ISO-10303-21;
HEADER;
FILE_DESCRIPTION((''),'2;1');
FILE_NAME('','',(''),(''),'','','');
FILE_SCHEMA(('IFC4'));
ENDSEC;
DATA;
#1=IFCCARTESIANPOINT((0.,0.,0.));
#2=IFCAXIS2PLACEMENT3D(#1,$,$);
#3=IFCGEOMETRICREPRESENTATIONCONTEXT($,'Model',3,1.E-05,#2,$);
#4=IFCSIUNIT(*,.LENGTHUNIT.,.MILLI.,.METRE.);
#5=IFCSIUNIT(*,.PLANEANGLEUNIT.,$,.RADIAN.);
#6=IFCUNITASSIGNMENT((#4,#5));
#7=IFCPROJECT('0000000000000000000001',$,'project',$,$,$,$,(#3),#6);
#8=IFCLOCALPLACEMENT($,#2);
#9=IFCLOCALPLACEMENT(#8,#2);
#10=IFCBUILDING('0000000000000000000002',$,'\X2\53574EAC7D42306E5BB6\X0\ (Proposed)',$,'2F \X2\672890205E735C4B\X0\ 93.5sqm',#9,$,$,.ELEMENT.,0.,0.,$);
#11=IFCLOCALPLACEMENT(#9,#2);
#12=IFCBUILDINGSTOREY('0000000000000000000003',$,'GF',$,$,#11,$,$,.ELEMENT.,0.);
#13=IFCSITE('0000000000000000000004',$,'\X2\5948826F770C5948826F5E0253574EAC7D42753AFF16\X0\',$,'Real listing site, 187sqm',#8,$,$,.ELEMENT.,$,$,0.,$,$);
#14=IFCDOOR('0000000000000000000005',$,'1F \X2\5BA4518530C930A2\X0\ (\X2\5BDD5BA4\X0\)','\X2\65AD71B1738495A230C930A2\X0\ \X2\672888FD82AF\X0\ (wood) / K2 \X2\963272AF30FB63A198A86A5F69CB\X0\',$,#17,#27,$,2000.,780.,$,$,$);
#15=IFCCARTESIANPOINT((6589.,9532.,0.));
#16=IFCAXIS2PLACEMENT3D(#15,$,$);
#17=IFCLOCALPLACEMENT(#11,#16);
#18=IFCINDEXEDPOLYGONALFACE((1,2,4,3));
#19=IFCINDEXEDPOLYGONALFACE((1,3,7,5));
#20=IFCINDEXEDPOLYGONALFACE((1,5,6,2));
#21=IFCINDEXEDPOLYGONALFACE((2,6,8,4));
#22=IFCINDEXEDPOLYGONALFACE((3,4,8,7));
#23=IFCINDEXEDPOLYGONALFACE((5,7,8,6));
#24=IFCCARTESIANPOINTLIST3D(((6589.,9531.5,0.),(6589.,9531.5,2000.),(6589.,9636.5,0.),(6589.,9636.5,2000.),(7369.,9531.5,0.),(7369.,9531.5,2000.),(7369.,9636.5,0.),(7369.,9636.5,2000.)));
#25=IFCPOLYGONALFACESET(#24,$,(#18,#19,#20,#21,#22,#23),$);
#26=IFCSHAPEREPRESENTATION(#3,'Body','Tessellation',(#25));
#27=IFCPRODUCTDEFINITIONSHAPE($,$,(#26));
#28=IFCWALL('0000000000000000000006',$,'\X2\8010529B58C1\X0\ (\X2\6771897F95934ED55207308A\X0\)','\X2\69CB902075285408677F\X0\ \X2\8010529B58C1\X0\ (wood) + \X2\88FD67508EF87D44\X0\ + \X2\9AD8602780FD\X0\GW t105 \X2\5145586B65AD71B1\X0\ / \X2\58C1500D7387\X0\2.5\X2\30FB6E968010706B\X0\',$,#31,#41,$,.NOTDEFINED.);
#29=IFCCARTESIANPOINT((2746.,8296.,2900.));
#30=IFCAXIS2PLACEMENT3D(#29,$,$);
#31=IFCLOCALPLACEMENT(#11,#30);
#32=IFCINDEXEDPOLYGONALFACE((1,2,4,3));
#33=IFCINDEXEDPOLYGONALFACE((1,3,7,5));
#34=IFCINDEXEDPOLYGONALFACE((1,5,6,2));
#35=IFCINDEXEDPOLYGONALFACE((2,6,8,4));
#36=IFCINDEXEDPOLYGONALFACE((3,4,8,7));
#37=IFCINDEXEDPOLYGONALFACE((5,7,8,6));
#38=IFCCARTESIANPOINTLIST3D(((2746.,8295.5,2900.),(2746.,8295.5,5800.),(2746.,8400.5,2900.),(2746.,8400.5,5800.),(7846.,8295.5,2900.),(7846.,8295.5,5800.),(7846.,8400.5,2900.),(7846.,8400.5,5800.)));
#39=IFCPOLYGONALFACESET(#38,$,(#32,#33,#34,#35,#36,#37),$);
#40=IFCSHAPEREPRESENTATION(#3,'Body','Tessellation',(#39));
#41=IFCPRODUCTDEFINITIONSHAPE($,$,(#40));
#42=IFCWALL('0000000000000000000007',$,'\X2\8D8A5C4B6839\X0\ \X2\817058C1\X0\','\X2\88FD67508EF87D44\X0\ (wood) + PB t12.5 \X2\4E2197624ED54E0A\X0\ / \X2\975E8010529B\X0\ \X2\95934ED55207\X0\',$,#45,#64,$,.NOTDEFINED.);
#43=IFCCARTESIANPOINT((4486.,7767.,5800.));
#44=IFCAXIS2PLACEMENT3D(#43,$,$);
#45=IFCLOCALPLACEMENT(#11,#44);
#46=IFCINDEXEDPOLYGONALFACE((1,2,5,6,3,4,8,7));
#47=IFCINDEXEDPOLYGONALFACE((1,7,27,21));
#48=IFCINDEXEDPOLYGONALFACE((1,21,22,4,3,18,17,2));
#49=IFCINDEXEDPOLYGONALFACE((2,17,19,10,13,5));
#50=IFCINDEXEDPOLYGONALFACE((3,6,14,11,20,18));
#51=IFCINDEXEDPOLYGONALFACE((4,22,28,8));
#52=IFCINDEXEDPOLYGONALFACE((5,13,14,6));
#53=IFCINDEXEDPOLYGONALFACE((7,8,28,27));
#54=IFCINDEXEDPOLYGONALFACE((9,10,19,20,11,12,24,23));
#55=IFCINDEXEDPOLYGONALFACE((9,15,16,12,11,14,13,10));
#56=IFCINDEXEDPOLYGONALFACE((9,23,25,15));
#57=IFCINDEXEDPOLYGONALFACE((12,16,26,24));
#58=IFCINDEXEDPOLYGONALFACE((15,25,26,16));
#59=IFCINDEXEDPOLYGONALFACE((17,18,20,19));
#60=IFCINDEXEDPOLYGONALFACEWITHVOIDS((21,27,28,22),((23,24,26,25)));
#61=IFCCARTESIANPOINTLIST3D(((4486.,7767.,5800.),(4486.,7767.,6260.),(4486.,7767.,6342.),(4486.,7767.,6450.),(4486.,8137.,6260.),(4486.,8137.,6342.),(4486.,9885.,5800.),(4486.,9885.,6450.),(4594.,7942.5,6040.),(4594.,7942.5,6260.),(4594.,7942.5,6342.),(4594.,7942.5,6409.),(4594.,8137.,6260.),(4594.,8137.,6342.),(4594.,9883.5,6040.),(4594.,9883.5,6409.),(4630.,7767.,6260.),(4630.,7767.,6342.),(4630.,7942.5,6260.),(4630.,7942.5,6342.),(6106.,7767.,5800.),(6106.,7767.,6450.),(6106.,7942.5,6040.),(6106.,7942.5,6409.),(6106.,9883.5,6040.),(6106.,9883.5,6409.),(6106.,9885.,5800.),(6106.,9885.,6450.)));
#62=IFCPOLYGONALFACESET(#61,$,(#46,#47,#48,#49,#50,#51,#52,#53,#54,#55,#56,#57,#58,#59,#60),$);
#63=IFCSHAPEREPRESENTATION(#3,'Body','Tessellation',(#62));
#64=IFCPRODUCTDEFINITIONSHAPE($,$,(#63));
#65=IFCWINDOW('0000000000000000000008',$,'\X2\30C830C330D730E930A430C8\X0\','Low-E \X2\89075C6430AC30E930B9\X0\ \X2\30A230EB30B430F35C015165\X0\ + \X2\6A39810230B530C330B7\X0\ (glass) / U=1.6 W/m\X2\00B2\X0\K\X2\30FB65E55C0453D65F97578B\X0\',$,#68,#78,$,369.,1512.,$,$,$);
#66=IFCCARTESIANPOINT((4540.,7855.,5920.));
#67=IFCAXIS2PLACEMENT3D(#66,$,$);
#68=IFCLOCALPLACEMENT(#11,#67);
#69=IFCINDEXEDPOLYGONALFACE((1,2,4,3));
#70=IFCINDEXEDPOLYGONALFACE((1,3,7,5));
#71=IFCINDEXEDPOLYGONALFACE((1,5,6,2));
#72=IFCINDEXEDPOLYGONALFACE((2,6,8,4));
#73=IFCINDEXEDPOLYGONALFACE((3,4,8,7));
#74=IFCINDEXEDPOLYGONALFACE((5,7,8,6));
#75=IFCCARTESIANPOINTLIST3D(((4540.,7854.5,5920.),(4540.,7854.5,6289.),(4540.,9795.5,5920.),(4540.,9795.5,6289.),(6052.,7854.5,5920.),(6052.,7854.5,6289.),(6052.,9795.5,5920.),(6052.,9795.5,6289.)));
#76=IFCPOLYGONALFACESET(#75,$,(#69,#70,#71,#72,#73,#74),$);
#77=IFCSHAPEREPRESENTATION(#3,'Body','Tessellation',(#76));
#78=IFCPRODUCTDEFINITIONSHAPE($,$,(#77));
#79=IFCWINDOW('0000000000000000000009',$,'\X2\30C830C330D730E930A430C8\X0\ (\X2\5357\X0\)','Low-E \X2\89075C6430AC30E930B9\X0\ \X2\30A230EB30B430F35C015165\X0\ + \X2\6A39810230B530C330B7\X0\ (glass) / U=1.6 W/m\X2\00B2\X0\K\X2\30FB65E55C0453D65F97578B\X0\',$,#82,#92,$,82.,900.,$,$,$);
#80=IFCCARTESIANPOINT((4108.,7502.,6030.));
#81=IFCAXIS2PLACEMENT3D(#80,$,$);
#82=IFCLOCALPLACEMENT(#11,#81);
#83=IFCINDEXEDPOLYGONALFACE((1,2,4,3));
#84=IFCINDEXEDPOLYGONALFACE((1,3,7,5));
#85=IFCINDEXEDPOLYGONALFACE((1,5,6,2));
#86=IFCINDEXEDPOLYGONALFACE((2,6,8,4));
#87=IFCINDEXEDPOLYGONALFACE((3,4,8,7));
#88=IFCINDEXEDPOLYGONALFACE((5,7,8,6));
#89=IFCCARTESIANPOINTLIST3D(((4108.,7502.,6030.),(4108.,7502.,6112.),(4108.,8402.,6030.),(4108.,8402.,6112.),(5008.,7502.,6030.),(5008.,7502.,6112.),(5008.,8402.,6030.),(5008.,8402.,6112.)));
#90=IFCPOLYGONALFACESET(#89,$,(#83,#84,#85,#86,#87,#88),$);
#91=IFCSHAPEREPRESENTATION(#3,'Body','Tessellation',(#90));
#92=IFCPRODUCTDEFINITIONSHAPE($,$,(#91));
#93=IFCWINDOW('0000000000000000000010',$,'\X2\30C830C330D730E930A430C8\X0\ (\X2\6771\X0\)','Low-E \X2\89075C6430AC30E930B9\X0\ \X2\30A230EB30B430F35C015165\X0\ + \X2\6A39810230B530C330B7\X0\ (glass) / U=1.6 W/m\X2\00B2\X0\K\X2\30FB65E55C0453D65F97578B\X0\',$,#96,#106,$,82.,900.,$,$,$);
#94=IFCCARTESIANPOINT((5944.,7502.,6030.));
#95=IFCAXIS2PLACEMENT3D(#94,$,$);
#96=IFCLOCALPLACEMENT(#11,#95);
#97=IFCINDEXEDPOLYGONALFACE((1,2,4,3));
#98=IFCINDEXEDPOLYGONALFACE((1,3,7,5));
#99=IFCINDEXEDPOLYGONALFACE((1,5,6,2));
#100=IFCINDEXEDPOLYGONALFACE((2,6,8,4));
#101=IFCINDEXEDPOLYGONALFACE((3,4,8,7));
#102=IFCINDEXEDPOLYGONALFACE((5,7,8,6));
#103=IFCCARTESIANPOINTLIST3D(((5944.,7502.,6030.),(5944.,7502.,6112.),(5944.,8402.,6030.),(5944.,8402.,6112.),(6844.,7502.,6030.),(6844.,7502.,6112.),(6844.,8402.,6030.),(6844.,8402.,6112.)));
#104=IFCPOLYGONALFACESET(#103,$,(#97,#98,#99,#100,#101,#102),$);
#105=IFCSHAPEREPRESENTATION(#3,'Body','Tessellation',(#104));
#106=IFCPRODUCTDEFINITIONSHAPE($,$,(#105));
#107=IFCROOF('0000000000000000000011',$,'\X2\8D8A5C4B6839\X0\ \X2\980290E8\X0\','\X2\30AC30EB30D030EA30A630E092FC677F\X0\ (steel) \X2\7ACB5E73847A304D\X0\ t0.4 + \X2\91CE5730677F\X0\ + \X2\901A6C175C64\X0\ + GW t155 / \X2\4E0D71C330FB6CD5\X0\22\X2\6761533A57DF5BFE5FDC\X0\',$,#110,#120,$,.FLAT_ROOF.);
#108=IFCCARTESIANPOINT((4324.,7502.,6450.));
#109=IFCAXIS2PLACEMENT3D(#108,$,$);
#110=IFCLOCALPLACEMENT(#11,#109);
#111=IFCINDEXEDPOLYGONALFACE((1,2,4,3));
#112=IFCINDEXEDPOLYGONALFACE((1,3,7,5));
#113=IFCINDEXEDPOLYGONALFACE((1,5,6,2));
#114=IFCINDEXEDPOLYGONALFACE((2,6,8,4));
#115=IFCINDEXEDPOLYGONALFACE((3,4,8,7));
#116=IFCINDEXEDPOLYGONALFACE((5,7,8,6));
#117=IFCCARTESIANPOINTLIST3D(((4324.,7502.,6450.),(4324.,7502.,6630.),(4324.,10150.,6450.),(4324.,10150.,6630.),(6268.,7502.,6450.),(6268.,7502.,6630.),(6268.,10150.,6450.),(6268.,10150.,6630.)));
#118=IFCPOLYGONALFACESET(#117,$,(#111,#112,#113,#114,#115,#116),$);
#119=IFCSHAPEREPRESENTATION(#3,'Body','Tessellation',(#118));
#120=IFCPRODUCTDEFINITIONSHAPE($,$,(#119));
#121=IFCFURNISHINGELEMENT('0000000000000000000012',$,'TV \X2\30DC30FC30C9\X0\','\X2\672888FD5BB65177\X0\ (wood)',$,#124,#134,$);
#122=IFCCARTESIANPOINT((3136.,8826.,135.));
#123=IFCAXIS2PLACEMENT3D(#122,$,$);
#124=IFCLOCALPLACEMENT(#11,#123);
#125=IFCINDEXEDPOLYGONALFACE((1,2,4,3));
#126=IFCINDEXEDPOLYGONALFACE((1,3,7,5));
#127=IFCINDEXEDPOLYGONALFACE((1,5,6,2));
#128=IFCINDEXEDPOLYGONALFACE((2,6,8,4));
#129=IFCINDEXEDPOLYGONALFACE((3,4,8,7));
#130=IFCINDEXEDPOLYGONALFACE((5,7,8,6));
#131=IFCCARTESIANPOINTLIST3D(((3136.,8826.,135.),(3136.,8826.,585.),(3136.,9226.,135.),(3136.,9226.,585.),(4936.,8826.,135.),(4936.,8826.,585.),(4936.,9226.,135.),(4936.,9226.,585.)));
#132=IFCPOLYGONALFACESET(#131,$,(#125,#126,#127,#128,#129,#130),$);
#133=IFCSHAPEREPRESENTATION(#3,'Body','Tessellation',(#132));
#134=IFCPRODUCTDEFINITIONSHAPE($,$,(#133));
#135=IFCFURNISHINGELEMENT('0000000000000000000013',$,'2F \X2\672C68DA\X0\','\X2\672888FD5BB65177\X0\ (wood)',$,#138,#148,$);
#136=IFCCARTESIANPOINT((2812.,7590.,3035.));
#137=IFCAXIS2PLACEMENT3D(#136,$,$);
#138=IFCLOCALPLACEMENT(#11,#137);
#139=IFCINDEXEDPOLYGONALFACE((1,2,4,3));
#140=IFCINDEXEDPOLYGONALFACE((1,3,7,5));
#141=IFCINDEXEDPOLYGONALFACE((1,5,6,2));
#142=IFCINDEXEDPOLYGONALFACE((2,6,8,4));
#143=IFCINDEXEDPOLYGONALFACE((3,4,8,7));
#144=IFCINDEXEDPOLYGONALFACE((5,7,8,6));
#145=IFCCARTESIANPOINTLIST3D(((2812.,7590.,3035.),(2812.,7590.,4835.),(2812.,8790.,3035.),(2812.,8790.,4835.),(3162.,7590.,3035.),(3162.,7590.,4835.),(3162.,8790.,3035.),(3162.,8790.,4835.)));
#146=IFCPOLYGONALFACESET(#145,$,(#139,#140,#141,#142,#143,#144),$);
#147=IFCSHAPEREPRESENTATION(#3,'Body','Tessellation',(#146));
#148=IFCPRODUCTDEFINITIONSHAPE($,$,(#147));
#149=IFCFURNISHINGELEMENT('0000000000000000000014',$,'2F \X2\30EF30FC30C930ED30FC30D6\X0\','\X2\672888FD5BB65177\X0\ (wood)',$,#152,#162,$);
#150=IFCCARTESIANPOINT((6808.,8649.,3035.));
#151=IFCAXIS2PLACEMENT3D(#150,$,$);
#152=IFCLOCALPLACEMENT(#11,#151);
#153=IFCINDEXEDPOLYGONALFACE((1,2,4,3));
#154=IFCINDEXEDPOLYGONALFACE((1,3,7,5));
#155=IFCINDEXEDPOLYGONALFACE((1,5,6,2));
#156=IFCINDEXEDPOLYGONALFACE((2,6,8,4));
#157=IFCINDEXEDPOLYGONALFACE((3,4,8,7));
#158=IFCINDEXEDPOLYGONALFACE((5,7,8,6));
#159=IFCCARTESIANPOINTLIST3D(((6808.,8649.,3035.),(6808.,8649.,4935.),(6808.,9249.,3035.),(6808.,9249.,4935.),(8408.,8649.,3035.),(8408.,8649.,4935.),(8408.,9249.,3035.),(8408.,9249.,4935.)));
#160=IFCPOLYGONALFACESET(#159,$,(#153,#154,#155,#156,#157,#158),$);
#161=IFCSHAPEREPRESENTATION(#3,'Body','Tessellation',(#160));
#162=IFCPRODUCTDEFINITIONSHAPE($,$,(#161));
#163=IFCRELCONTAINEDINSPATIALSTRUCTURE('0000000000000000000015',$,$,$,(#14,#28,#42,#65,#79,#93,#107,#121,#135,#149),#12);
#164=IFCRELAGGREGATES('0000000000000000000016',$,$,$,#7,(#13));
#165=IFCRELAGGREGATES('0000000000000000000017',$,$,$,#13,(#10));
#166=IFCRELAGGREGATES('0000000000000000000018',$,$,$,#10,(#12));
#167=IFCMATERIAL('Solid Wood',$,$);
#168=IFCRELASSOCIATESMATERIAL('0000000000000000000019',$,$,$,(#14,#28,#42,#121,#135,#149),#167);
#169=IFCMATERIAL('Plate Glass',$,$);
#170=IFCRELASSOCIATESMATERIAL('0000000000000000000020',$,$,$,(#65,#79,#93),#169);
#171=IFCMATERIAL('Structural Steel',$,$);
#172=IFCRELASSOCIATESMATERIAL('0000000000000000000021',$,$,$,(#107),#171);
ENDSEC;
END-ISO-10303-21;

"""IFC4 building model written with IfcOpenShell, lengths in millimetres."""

from ifc_helpers import new_model, si_unit, frame, frame_2d, origin, place, context, project, spatial, rectangle, extrude, material, element, fill, save


model = new_model("IFC4")

# Units and contexts
model_context = context("Model", 3, precision=1e-05, world=origin())
ifc_project = project(units=[si_unit("LENGTHUNIT", "METRE", prefix="MILLI"), si_unit("PLANEANGLEUNIT", "RADIAN")], contexts=[model_context])

# Site, building, storey
site_placement = place(None, origin())
site = spatial("IfcSite", under=ifc_project, at=site_placement, Name="奈良県奈良市南京終町６", ObjectType="Real listing site, 187sqm", CompositionType="ELEMENT", RefElevation=0.0)
building_placement = place(site_placement, origin())
building = spatial("IfcBuilding", under=site, at=building_placement, Name="南京終の家 (Proposed)", ObjectType="2F 木造平屋 93.5sqm", CompositionType="ELEMENT", ElevationOfRefHeight=0.0, ElevationOfTerrain=0.0)
storey_placement = place(building_placement, origin())
storey = spatial("IfcBuildingStorey", under=building, at=storey_placement, Name="GF", CompositionType="ELEMENT", Elevation=0.0)

# Shared definitions
ifc_material_1 = material(Name="Solid Wood")

# Door
door_placement = place(storey_placement, frame((6589.0, 9532.0, 0.0)))
element("IfcDoor", 1, at=door_placement, inside=storey, material=ifc_material_1, Name="1F 室内ドア (寝室)", Description="断熱玄関ドア 木製芯 (wood) / K2 防犯・採風機構", OverallHeight=2000.0, OverallWidth=780.0, context=model_context, shape_type="SweptSolid", body=[
    extrude(rectangle(XDim=780.0, YDim=105.0, at=frame_2d((390.0, 52.0))), frame((6589.0, 9532.0, 0.0)), (0.0, 0.0, 1.0), 2000.0),
])

# Wall
wall_1_placement = place(storey_placement, frame((2746.0, 8296.0, 2900.0)))
element("IfcWall", 2, at=wall_1_placement, inside=storey, material=ifc_material_1, Name="耐力壁 (東西間仕切り)", Description="構造用合板 耐力壁 (wood) + 製材軸組 + 高性能GW t105 充填断熱 / 壁倍率2.5・準耐火", PredefinedType="NOTDEFINED", context=model_context, shape_type="SweptSolid", body=[
    extrude(rectangle(XDim=5100.0, YDim=105.0, at=frame_2d((2550.0, 52.0))), frame((2746.0, 8296.0, 2900.0)), (0.0, 0.0, 1.0), 2900.0),
])

# Wall, openings, windows
wall_2_placement = place(storey_placement, frame((4486.0, 7767.0, 5800.0)))
wall_2 = element("IfcWall", 3, at=wall_2_placement, inside=storey, material=ifc_material_1, Name="越屋根 腰壁", Description="製材軸組 (wood) + PB t12.5 両面仕上 / 非耐力 間仕切", PredefinedType="NOTDEFINED", context=model_context, shape_type="SweptSolid", body=[
    extrude(rectangle(XDim=1620.0, YDim=2118.0, at=frame_2d((810.0, 1059.0))), frame((4486.0, 7767.0, 5800.0)), (0.0, 0.0, 1.0), 650.0),
])
opening_1_placement = place(storey_placement, frame((4540.0, 7855.0, 5920.0)))
opening_1 = element("IfcOpeningElement", 4, at=opening_1_placement, cuts=wall_2, PredefinedType="NOTDEFINED", context=model_context, shape_type="SweptSolid", body=[
    extrude(rectangle(XDim=1512.0, YDim=1941.0, at=frame_2d((756.0, 970.0))), frame((4540.0, 7855.0, 5920.0)), (0.0, 0.0, 1.0), 369.0),
])
opening_2_placement = place(storey_placement, frame((4108.0, 7502.0, 6030.0)))
opening_2 = element("IfcOpeningElement", 5, at=opening_2_placement, cuts=wall_2, PredefinedType="NOTDEFINED", context=model_context, shape_type="SweptSolid", body=[
    extrude(rectangle(XDim=900.0, YDim=900.0, at=frame_2d((450.0, 450.0))), frame((4108.0, 7502.0, 6030.0)), (0.0, 0.0, 1.0), 82.0),
])
opening_3_placement = place(storey_placement, frame((5944.0, 7502.0, 6030.0)))
opening_3 = element("IfcOpeningElement", 6, at=opening_3_placement, cuts=wall_2, PredefinedType="NOTDEFINED", context=model_context, shape_type="SweptSolid", body=[
    extrude(rectangle(XDim=900.0, YDim=900.0, at=frame_2d((450.0, 450.0))), frame((5944.0, 7502.0, 6030.0)), (0.0, 0.0, 1.0), 82.0),
])
ifc_material_2 = material(Name="Plate Glass")
window_1_placement = place(storey_placement, frame((4540.0, 7855.0, 5920.0)))
window_1 = element("IfcWindow", 7, at=window_1_placement, inside=storey, material=ifc_material_2, Name="トップライト", Description="Low-E 複層ガラス アルゴン封入 + 樹脂サッシ (glass) / U=1.6 W/m²K・日射取得型", OverallHeight=369.0, OverallWidth=1512.0, context=model_context, shape_type="SweptSolid", body=[
    extrude(rectangle(XDim=1512.0, YDim=1941.0, at=frame_2d((756.0, 970.0))), frame((4540.0, 7855.0, 5920.0)), (0.0, 0.0, 1.0), 369.0),
])
fill(opening_1, window_1)
window_2_placement = place(storey_placement, frame((4108.0, 7502.0, 6030.0)))
window_2 = element("IfcWindow", 8, at=window_2_placement, inside=storey, material=ifc_material_2, Name="トップライト (南)", Description="Low-E 複層ガラス アルゴン封入 + 樹脂サッシ (glass) / U=1.6 W/m²K・日射取得型", OverallHeight=82.0, OverallWidth=900.0, context=model_context, shape_type="SweptSolid", body=[
    extrude(rectangle(XDim=900.0, YDim=900.0, at=frame_2d((450.0, 450.0))), frame((4108.0, 7502.0, 6030.0)), (0.0, 0.0, 1.0), 82.0),
])
fill(opening_2, window_2)
window_3_placement = place(storey_placement, frame((5944.0, 7502.0, 6030.0)))
window_3 = element("IfcWindow", 9, at=window_3_placement, inside=storey, material=ifc_material_2, Name="トップライト (東)", Description="Low-E 複層ガラス アルゴン封入 + 樹脂サッシ (glass) / U=1.6 W/m²K・日射取得型", OverallHeight=82.0, OverallWidth=900.0, context=model_context, shape_type="SweptSolid", body=[
    extrude(rectangle(XDim=900.0, YDim=900.0, at=frame_2d((450.0, 450.0))), frame((5944.0, 7502.0, 6030.0)), (0.0, 0.0, 1.0), 82.0),
])
fill(opening_3, window_3)

# Roof
ifc_material_3 = material(Name="Structural Steel")
roof_placement = place(storey_placement, frame((4324.0, 7502.0, 6450.0)))
element("IfcRoof", 10, at=roof_placement, inside=storey, material=ifc_material_3, Name="越屋根 頂部", Description="ガルバリウム鋼板 (steel) 立平葺き t0.4 + 野地板 + 通気層 + GW t155 / 不燃・法22条区域対応", PredefinedType="FLAT_ROOF", context=model_context, shape_type="SweptSolid", body=[
    extrude(rectangle(XDim=1944.0, YDim=2648.0, at=frame_2d((972.0, 1324.0))), frame((4324.0, 7502.0, 6450.0)), (0.0, 0.0, 1.0), 180.0),
])

# Furnishing elements
furnishing_1_placement = place(storey_placement, frame((3136.0, 8826.0, 135.0)))
element("IfcFurnishingElement", 11, at=furnishing_1_placement, inside=storey, material=ifc_material_1, Name="TV ボード", Description="木製家具 (wood)", context=model_context, shape_type="SweptSolid", body=[
    extrude(rectangle(XDim=1800.0, YDim=400.0, at=frame_2d((900.0, 200.0))), frame((3136.0, 8826.0, 135.0)), (0.0, 0.0, 1.0), 450.0),
])
furnishing_2_placement = place(storey_placement, frame((2812.0, 7590.0, 3035.0)))
element("IfcFurnishingElement", 12, at=furnishing_2_placement, inside=storey, material=ifc_material_1, Name="2F 本棚", Description="木製家具 (wood)", context=model_context, shape_type="SweptSolid", body=[
    extrude(rectangle(XDim=350.0, YDim=1200.0, at=frame_2d((175.0, 600.0))), frame((2812.0, 7590.0, 3035.0)), (0.0, 0.0, 1.0), 1800.0),
])
furnishing_3_placement = place(storey_placement, frame((6808.0, 8649.0, 3035.0)))
element("IfcFurnishingElement", 13, at=furnishing_3_placement, inside=storey, material=ifc_material_1, Name="2F ワードローブ", Description="木製家具 (wood)", context=model_context, shape_type="SweptSolid", body=[
    extrude(rectangle(XDim=1600.0, YDim=600.0, at=frame_2d((800.0, 300.0))), frame((6808.0, 8649.0, 3035.0)), (0.0, 0.0, 1.0), 1900.0),
])

save(model, "model.ifc")
